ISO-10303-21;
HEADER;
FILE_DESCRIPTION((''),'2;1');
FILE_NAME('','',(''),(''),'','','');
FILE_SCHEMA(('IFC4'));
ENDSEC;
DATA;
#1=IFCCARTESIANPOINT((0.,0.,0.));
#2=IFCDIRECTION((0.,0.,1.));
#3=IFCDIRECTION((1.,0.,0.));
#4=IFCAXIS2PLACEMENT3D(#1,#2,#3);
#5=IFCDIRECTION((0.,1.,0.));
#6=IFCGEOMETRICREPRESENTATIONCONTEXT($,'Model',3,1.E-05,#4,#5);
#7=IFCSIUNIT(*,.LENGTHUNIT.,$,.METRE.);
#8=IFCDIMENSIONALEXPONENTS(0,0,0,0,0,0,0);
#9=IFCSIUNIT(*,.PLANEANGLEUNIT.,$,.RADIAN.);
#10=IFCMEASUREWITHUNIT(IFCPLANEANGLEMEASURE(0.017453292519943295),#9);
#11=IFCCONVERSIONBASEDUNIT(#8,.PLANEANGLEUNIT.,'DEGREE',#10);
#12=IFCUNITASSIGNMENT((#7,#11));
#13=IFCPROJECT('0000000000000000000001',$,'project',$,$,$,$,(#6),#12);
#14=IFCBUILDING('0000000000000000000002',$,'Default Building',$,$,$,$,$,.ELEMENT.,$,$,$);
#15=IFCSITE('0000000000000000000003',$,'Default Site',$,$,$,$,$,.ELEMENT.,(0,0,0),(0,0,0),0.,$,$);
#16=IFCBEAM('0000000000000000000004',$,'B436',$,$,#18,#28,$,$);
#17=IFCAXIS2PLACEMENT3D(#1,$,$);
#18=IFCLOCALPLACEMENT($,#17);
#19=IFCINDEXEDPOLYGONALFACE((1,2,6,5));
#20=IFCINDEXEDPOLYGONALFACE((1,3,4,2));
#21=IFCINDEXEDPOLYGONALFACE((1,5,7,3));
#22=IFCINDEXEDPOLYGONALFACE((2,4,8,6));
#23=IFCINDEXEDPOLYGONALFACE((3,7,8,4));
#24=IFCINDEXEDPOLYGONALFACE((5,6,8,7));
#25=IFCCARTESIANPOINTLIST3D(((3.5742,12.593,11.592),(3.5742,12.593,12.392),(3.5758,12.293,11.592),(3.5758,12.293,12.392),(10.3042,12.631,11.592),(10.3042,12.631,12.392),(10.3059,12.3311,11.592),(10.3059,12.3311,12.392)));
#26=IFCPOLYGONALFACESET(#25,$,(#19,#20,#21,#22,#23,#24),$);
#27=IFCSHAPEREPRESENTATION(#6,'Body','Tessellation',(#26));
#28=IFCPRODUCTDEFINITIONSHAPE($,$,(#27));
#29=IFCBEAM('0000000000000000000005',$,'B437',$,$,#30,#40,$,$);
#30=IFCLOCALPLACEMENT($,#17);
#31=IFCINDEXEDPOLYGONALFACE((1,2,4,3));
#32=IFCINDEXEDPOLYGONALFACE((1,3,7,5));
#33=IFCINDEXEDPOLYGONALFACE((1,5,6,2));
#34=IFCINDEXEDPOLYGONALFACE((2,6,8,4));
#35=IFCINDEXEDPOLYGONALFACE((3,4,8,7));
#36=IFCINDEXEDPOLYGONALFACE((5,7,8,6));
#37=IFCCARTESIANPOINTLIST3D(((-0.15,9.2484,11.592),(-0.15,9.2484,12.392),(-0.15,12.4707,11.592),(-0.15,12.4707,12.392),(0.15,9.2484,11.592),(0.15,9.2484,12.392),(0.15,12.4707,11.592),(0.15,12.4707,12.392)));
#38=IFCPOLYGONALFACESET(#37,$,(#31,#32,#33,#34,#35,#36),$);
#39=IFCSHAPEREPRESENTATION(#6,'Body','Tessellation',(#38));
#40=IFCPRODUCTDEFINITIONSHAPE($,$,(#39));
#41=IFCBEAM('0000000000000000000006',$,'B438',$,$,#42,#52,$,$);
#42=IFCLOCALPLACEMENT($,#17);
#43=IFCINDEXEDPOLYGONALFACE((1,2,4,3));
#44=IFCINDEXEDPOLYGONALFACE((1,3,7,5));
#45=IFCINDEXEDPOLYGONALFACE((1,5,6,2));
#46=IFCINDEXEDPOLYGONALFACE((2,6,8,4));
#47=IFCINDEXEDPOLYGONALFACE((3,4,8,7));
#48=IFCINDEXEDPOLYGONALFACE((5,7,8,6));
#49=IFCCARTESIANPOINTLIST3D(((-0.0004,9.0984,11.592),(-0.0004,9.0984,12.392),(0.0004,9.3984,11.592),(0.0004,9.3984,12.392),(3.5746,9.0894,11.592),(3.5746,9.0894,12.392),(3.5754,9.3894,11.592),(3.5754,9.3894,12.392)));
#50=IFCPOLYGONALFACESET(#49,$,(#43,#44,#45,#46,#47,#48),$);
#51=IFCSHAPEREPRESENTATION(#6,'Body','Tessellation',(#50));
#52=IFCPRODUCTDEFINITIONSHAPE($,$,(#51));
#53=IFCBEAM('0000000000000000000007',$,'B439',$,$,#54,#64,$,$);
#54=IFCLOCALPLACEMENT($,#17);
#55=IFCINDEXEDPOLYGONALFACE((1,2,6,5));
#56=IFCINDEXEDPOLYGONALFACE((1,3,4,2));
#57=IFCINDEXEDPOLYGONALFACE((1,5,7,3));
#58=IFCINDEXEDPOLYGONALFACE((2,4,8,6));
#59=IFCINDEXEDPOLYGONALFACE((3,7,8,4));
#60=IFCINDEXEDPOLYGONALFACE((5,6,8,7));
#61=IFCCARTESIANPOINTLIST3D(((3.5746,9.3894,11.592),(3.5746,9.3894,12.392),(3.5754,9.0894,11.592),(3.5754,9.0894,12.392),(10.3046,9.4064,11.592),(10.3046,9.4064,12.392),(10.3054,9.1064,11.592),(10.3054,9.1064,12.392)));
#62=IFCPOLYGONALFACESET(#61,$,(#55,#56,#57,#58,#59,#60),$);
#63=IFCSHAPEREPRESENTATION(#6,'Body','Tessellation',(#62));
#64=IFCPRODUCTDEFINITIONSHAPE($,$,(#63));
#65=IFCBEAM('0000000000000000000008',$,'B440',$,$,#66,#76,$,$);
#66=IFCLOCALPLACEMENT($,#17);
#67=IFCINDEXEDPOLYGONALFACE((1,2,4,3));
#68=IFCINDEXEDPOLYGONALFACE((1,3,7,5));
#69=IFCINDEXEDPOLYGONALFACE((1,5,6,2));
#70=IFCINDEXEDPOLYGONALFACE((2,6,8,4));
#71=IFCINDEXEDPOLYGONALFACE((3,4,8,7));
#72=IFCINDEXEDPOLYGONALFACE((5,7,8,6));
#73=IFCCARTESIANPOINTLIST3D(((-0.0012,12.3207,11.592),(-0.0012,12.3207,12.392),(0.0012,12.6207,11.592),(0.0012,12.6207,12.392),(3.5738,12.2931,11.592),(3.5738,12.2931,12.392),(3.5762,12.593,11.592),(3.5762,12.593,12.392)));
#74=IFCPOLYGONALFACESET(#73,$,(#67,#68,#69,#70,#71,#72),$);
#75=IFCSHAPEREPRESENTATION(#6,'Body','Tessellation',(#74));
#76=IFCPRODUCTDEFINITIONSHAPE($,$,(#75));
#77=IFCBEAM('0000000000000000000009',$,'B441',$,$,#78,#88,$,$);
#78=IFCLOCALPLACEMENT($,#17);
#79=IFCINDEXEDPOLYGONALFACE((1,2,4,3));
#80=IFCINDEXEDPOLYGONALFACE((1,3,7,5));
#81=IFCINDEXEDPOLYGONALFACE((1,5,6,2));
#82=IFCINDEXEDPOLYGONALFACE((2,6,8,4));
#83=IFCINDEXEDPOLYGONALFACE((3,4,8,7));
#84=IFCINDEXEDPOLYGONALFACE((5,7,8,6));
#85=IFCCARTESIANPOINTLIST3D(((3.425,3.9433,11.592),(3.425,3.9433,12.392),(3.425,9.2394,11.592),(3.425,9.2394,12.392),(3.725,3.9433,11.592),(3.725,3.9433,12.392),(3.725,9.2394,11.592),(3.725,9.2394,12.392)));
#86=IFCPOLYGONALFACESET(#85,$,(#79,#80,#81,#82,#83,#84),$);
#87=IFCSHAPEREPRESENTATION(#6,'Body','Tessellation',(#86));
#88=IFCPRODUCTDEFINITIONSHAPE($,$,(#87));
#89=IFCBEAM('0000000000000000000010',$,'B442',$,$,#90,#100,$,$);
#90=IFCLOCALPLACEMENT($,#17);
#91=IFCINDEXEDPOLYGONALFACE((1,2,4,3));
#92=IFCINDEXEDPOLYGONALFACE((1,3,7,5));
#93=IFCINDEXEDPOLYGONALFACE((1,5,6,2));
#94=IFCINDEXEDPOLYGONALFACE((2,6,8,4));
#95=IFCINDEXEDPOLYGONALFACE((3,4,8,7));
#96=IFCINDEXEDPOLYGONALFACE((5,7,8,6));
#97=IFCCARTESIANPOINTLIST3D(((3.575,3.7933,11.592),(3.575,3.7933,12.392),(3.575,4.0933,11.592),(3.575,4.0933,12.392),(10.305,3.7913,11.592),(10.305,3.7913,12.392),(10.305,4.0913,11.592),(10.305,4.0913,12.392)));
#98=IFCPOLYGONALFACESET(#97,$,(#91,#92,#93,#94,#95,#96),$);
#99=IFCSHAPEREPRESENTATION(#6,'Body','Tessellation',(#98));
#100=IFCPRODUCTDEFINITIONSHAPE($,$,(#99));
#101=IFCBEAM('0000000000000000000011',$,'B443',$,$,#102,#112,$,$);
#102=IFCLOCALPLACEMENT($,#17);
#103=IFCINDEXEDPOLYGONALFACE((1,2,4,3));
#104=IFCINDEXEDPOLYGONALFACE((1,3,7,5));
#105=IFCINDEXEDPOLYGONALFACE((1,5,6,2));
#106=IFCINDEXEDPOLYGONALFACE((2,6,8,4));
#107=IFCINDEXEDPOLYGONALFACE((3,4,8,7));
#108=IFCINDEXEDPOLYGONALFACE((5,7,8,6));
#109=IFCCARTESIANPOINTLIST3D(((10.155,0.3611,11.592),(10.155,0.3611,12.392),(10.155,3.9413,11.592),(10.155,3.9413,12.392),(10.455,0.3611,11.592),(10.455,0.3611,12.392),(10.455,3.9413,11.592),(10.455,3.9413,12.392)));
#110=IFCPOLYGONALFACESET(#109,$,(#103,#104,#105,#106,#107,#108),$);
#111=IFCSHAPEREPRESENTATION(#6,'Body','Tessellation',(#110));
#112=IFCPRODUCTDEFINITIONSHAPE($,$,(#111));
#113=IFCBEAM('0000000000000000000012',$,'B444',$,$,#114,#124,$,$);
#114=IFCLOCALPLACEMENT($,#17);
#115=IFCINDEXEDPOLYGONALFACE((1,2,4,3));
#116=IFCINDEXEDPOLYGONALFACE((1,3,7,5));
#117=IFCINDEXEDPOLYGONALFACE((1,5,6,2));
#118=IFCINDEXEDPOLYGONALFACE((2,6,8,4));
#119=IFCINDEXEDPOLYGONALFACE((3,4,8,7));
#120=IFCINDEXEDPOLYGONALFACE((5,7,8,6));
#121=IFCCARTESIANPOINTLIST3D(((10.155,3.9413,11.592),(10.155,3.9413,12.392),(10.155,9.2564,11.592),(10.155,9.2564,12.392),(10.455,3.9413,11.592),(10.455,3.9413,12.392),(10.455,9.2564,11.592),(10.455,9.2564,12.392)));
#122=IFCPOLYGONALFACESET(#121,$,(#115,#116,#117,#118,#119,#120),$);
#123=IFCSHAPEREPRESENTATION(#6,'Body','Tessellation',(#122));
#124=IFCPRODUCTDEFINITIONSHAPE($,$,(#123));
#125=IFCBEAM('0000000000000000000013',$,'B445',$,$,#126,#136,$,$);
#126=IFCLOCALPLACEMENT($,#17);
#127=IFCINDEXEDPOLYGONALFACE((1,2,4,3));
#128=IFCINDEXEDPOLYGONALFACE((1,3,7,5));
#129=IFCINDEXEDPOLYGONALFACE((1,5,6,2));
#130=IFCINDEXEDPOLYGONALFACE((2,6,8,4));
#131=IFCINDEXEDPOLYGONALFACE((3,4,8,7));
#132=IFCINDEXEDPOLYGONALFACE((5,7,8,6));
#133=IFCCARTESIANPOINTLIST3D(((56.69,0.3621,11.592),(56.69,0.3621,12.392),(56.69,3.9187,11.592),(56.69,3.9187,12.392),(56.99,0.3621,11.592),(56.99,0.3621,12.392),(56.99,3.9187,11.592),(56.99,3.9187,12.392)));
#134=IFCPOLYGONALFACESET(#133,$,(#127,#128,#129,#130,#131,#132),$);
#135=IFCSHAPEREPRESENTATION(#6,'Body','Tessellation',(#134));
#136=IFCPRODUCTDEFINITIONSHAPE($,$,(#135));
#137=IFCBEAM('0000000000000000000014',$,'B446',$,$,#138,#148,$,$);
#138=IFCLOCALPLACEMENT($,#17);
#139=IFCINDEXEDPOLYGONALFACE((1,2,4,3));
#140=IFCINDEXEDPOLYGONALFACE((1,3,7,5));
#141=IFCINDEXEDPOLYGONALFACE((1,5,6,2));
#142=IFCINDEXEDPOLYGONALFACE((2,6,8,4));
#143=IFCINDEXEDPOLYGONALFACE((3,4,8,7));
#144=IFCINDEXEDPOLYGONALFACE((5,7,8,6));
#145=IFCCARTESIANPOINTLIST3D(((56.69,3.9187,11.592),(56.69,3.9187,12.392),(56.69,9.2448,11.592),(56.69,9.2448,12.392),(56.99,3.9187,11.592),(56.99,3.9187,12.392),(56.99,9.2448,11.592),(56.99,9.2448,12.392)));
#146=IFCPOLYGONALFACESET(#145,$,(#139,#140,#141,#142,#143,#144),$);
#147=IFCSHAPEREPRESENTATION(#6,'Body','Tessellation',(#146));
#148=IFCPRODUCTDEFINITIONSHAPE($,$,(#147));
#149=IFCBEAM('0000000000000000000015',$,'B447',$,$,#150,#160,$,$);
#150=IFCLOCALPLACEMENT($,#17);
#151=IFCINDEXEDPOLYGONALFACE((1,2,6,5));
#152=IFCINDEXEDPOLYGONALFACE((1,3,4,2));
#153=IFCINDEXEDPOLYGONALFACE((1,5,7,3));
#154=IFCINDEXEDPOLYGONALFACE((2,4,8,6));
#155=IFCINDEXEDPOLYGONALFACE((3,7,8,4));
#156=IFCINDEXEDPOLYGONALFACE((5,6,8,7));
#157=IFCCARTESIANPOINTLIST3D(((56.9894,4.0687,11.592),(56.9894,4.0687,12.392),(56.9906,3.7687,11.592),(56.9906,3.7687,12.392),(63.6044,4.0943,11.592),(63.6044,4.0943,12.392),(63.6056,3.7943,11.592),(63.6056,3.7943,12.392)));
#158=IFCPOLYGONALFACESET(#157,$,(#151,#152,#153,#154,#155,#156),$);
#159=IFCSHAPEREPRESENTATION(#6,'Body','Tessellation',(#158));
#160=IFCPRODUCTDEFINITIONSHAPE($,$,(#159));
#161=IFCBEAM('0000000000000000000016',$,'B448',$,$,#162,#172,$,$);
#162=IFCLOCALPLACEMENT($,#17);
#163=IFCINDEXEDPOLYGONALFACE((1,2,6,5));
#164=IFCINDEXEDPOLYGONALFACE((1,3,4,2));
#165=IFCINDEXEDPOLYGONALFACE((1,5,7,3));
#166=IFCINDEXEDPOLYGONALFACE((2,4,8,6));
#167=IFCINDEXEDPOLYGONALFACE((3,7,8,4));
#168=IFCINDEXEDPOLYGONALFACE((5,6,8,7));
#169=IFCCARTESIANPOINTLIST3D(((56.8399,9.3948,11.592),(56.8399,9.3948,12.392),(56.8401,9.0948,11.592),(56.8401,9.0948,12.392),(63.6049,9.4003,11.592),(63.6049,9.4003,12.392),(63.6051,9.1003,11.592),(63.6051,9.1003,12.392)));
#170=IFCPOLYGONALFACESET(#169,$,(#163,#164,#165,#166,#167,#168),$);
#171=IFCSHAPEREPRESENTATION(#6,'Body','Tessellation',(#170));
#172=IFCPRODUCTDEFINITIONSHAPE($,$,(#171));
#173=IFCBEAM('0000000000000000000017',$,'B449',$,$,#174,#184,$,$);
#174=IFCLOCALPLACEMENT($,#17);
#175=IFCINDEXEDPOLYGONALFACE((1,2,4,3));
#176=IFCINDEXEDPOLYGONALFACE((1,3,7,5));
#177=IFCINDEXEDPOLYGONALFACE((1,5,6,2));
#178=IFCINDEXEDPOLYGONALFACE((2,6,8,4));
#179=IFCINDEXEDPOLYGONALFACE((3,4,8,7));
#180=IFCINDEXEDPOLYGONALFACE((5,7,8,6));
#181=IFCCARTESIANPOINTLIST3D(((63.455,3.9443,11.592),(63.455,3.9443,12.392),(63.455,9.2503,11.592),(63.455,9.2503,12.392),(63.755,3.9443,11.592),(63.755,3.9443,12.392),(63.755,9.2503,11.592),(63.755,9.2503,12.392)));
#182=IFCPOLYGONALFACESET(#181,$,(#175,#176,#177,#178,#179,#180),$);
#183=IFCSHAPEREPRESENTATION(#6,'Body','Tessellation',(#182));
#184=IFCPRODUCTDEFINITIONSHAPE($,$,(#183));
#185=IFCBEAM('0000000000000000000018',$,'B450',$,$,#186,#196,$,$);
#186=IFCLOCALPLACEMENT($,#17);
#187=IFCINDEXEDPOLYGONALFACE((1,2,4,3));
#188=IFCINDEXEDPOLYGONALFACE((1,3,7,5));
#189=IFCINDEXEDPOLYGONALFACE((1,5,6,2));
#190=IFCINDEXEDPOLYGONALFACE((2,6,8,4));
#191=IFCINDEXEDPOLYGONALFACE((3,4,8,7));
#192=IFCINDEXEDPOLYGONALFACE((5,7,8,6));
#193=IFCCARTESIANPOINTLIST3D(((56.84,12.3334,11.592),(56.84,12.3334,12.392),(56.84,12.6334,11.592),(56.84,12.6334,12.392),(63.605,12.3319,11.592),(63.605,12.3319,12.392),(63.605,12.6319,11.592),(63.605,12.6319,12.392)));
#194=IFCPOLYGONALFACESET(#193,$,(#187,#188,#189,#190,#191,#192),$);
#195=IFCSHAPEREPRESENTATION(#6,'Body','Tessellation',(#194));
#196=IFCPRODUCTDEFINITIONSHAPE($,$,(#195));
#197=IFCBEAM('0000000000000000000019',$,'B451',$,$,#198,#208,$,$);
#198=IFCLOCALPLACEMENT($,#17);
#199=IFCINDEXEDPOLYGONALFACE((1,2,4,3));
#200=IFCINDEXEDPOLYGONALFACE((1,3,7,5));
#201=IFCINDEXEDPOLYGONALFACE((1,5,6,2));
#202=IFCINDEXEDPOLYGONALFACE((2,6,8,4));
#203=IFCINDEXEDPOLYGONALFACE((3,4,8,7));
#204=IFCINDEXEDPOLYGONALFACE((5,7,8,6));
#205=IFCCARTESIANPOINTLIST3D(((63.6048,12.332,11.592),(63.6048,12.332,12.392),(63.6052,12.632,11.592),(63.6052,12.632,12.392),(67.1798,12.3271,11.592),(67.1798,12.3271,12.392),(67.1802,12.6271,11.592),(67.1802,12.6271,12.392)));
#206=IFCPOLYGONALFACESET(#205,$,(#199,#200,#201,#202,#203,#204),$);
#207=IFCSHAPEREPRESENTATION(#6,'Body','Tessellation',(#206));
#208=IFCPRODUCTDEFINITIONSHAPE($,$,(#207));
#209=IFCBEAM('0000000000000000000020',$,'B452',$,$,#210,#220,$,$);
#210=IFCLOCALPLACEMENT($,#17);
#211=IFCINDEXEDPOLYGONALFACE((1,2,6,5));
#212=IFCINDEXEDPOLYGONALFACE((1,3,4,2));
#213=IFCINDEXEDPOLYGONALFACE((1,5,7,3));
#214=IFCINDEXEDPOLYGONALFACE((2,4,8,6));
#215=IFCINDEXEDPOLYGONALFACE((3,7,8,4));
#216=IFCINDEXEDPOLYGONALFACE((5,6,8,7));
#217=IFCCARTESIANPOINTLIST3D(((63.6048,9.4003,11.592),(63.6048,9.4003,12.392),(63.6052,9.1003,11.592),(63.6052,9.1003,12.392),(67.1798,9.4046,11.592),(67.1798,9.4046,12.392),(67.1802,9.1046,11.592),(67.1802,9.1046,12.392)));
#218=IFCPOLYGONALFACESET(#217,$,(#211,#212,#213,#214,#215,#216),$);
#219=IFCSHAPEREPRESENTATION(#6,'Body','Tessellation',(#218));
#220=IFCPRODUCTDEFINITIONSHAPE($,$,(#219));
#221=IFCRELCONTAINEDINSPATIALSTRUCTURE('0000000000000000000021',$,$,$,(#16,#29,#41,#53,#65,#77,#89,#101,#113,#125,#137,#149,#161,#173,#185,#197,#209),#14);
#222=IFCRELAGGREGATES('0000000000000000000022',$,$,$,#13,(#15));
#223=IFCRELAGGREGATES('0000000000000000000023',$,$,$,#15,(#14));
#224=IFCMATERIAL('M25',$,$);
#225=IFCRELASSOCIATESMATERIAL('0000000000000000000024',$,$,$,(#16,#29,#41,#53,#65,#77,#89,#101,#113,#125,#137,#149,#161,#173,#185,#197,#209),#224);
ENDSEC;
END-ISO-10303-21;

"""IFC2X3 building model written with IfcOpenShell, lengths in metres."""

from ifc_helpers import new_model, entity, si_unit, converted_unit, direction, frame, frame_2d, origin_with_axes, place, context, project, spatial, rectangle, extrude, material, element, save


model = new_model("IFC2X3")

# Units and contexts
model_context = context("Model", 3, precision=1e-05, world=origin_with_axes(), true_north=direction((0.0, 1.0, 0.0)))
ifc_project = project(units=[si_unit("LENGTHUNIT", "METRE"), converted_unit("PLANEANGLEUNIT", "DEGREE", entity("IfcPlaneAngleMeasure", 0.017453292519943295), si_unit("PLANEANGLEUNIT", "RADIAN"), dimensions=[0, 0, 0, 0, 0, 0, 0])], contexts=[model_context])

# Site, building
site = spatial("IfcSite", under=ifc_project, Name="Default Site", CompositionType="ELEMENT", RefLatitude=(0, 0, 0), RefLongitude=(0, 0, 0), RefElevation=0.0)
building = spatial("IfcBuilding", under=site, Name="Default Building", CompositionType="ELEMENT")

# Beams
ifc_material = material(Name="M25")
placement = place(None, origin_with_axes())
element("IfcBeam", 1, at=placement, inside=building, material=ifc_material, Name="B436", context=model_context, shape_type="SweptSolid", body=[
    extrude(rectangle(XDim=0.3, YDim=0.8, at=frame_2d((0.0, 0.0), x_axis=(0.0, 1.0, 0.0))), frame((3.575, 12.443, 11.992), z_axis=(0.999984, 0.005654, 0.0), x_axis=(0.0, 0.0, -1.0)), (0.0, 0.0, 1.0), 6.7301),
])
element("IfcBeam", 2, at=placement, inside=building, material=ifc_material, Name="B437", context=model_context, shape_type="SweptSolid", body=[
    extrude(rectangle(XDim=0.3, YDim=0.8, at=frame_2d((0.0, 0.0), x_axis=(0.0, 1.0, 0.0))), frame((0.0, 9.2484, 11.992), z_axis=(0.0, 1.0, 0.0), x_axis=(0.0, 0.0, -1.0)), (0.0, 0.0, 1.0), 3.2223),
])
element("IfcBeam", 3, at=placement, inside=building, material=ifc_material, Name="B438", context=model_context, shape_type="SweptSolid", body=[
    extrude(rectangle(XDim=0.3, YDim=0.8, at=frame_2d((0.0, 0.0), x_axis=(0.0, 1.0, 0.0))), frame((0.0, 9.2484, 11.992), z_axis=(0.999997, -0.002499, 0.0), x_axis=(0.0, 0.0, -1.0)), (0.0, 0.0, 1.0), 3.575),
])
element("IfcBeam", 4, at=placement, inside=building, material=ifc_material, Name="B439", context=model_context, shape_type="SweptSolid", body=[
    extrude(rectangle(XDim=0.3, YDim=0.8, at=frame_2d((0.0, 0.0), x_axis=(0.0, 1.0, 0.0))), frame((3.575, 9.2394, 11.992), z_axis=(0.999997, 0.002522, 0.0), x_axis=(0.0, 0.0, -1.0)), (0.0, 0.0, 1.0), 6.73),
])
element("IfcBeam", 5, at=placement, inside=building, material=ifc_material, Name="B440", context=model_context, shape_type="SweptSolid", body=[
    extrude(rectangle(XDim=0.3, YDim=0.8, at=frame_2d((0.0, 0.0), x_axis=(0.0, 1.0, 0.0))), frame((0.0, 12.4707, 11.992), z_axis=(0.99997, -0.007734, 0.0), x_axis=(0.0, 0.0, -1.0)), (0.0, 0.0, 1.0), 3.5751),
])
element("IfcBeam", 6, at=placement, inside=building, material=ifc_material, Name="B441", context=model_context, shape_type="SweptSolid", body=[
    extrude(rectangle(XDim=0.3, YDim=0.8, at=frame_2d((0.0, 0.0), x_axis=(0.0, 1.0, 0.0))), frame((3.575, 3.9433, 11.992), z_axis=(0.0, 1.0, 0.0), x_axis=(0.0, 0.0, -1.0)), (0.0, 0.0, 1.0), 5.2961),
])
element("IfcBeam", 7, at=placement, inside=building, material=ifc_material, Name="B442", context=model_context, shape_type="SweptSolid", body=[
    extrude(rectangle(XDim=0.3, YDim=0.8, at=frame_2d((0.0, 0.0), x_axis=(0.0, 1.0, 0.0))), frame((3.575, 3.9433, 11.992), z_axis=(1.0, -0.000302, 0.0), x_axis=(0.0, 0.0, -1.0)), (0.0, 0.0, 1.0), 6.73),
])
element("IfcBeam", 8, at=placement, inside=building, material=ifc_material, Name="B443", context=model_context, shape_type="SweptSolid", body=[
    extrude(rectangle(XDim=0.3, YDim=0.8, at=frame_2d((0.0, 0.0), x_axis=(0.0, 1.0, 0.0))), frame((10.305, 3.9413, 11.992), z_axis=(0.0, -1.0, 0.0), x_axis=(0.0, 0.0, -1.0)), (0.0, 0.0, 1.0), 3.5802),
])
element("IfcBeam", 9, at=placement, inside=building, material=ifc_material, Name="B444", context=model_context, shape_type="SweptSolid", body=[
    extrude(rectangle(XDim=0.3, YDim=0.8, at=frame_2d((0.0, 0.0), x_axis=(0.0, 1.0, 0.0))), frame((10.305, 3.9413, 11.992), z_axis=(0.0, 1.0, 0.0), x_axis=(0.0, 0.0, -1.0)), (0.0, 0.0, 1.0), 5.3151),
])
element("IfcBeam", 10, at=placement, inside=building, material=ifc_material, Name="B445", context=model_context, shape_type="SweptSolid", body=[
    extrude(rectangle(XDim=0.3, YDim=0.8, at=frame_2d((0.0, 0.0), x_axis=(0.0, 1.0, 0.0))), frame((56.84, 0.3621, 11.992), z_axis=(0.0, 1.0, 0.0), x_axis=(0.0, 0.0, -1.0)), (0.0, 0.0, 1.0), 3.5566),
])
element("IfcBeam", 11, at=placement, inside=building, material=ifc_material, Name="B446", context=model_context, shape_type="SweptSolid", body=[
    extrude(rectangle(XDim=0.3, YDim=0.8, at=frame_2d((0.0, 0.0), x_axis=(0.0, 1.0, 0.0))), frame((56.84, 3.9187, 11.992), z_axis=(0.0, 1.0, 0.0), x_axis=(0.0, 0.0, -1.0)), (0.0, 0.0, 1.0), 5.3261),
])
element("IfcBeam", 12, at=placement, inside=building, material=ifc_material, Name="B447", context=model_context, shape_type="SweptSolid", body=[
    extrude(rectangle(XDim=0.3, YDim=0.8, at=frame_2d((0.0, 0.0), x_axis=(0.0, 1.0, 0.0))), frame((56.99, 3.9187, 11.992), z_axis=(0.999993, 0.003873, 0.0), x_axis=(0.0, 0.0, -1.0)), (0.0, 0.0, 1.0), 6.6151),
])
element("IfcBeam", 13, at=placement, inside=building, material=ifc_material, Name="B448", context=model_context, shape_type="SweptSolid", body=[
    extrude(rectangle(XDim=0.3, YDim=0.8, at=frame_2d((0.0, 0.0), x_axis=(0.0, 1.0, 0.0))), frame((56.84, 9.2448, 11.992), z_axis=(1.0, 0.000816, 0.0), x_axis=(0.0, 0.0, -1.0)), (0.0, 0.0, 1.0), 6.765),
])
element("IfcBeam", 14, at=placement, inside=building, material=ifc_material, Name="B449", context=model_context, shape_type="SweptSolid", body=[
    extrude(rectangle(XDim=0.3, YDim=0.8, at=frame_2d((0.0, 0.0), x_axis=(0.0, 1.0, 0.0))), frame((63.605, 3.9443, 11.992), z_axis=(0.0, 1.0, 0.0), x_axis=(0.0, 0.0, -1.0)), (0.0, 0.0, 1.0), 5.306),
])
element("IfcBeam", 15, at=placement, inside=building, material=ifc_material, Name="B450", context=model_context, shape_type="SweptSolid", body=[
    extrude(rectangle(XDim=0.3, YDim=0.8, at=frame_2d((0.0, 0.0), x_axis=(0.0, 1.0, 0.0))), frame((56.84, 12.4834, 11.992), z_axis=(1.0, -0.000216, 0.0), x_axis=(0.0, 0.0, -1.0)), (0.0, 0.0, 1.0), 6.765),
])
element("IfcBeam", 16, at=placement, inside=building, material=ifc_material, Name="B451", context=model_context, shape_type="SweptSolid", body=[
    extrude(rectangle(XDim=0.3, YDim=0.8, at=frame_2d((0.0, 0.0), x_axis=(0.0, 1.0, 0.0))), frame((63.605, 12.482, 11.992), z_axis=(0.999999, -0.001379, 0.0), x_axis=(0.0, 0.0, -1.0)), (0.0, 0.0, 1.0), 3.575),
])
element("IfcBeam", 17, at=placement, inside=building, material=ifc_material, Name="B452", context=model_context, shape_type="SweptSolid", body=[
    extrude(rectangle(XDim=0.3, YDim=0.8, at=frame_2d((0.0, 0.0), x_axis=(0.0, 1.0, 0.0))), frame((63.605, 9.2503, 11.992), z_axis=(0.999999, 0.001188, 0.0), x_axis=(0.0, 0.0, -1.0)), (0.0, 0.0, 1.0), 3.575),
])

save(model, "model.ifc")
